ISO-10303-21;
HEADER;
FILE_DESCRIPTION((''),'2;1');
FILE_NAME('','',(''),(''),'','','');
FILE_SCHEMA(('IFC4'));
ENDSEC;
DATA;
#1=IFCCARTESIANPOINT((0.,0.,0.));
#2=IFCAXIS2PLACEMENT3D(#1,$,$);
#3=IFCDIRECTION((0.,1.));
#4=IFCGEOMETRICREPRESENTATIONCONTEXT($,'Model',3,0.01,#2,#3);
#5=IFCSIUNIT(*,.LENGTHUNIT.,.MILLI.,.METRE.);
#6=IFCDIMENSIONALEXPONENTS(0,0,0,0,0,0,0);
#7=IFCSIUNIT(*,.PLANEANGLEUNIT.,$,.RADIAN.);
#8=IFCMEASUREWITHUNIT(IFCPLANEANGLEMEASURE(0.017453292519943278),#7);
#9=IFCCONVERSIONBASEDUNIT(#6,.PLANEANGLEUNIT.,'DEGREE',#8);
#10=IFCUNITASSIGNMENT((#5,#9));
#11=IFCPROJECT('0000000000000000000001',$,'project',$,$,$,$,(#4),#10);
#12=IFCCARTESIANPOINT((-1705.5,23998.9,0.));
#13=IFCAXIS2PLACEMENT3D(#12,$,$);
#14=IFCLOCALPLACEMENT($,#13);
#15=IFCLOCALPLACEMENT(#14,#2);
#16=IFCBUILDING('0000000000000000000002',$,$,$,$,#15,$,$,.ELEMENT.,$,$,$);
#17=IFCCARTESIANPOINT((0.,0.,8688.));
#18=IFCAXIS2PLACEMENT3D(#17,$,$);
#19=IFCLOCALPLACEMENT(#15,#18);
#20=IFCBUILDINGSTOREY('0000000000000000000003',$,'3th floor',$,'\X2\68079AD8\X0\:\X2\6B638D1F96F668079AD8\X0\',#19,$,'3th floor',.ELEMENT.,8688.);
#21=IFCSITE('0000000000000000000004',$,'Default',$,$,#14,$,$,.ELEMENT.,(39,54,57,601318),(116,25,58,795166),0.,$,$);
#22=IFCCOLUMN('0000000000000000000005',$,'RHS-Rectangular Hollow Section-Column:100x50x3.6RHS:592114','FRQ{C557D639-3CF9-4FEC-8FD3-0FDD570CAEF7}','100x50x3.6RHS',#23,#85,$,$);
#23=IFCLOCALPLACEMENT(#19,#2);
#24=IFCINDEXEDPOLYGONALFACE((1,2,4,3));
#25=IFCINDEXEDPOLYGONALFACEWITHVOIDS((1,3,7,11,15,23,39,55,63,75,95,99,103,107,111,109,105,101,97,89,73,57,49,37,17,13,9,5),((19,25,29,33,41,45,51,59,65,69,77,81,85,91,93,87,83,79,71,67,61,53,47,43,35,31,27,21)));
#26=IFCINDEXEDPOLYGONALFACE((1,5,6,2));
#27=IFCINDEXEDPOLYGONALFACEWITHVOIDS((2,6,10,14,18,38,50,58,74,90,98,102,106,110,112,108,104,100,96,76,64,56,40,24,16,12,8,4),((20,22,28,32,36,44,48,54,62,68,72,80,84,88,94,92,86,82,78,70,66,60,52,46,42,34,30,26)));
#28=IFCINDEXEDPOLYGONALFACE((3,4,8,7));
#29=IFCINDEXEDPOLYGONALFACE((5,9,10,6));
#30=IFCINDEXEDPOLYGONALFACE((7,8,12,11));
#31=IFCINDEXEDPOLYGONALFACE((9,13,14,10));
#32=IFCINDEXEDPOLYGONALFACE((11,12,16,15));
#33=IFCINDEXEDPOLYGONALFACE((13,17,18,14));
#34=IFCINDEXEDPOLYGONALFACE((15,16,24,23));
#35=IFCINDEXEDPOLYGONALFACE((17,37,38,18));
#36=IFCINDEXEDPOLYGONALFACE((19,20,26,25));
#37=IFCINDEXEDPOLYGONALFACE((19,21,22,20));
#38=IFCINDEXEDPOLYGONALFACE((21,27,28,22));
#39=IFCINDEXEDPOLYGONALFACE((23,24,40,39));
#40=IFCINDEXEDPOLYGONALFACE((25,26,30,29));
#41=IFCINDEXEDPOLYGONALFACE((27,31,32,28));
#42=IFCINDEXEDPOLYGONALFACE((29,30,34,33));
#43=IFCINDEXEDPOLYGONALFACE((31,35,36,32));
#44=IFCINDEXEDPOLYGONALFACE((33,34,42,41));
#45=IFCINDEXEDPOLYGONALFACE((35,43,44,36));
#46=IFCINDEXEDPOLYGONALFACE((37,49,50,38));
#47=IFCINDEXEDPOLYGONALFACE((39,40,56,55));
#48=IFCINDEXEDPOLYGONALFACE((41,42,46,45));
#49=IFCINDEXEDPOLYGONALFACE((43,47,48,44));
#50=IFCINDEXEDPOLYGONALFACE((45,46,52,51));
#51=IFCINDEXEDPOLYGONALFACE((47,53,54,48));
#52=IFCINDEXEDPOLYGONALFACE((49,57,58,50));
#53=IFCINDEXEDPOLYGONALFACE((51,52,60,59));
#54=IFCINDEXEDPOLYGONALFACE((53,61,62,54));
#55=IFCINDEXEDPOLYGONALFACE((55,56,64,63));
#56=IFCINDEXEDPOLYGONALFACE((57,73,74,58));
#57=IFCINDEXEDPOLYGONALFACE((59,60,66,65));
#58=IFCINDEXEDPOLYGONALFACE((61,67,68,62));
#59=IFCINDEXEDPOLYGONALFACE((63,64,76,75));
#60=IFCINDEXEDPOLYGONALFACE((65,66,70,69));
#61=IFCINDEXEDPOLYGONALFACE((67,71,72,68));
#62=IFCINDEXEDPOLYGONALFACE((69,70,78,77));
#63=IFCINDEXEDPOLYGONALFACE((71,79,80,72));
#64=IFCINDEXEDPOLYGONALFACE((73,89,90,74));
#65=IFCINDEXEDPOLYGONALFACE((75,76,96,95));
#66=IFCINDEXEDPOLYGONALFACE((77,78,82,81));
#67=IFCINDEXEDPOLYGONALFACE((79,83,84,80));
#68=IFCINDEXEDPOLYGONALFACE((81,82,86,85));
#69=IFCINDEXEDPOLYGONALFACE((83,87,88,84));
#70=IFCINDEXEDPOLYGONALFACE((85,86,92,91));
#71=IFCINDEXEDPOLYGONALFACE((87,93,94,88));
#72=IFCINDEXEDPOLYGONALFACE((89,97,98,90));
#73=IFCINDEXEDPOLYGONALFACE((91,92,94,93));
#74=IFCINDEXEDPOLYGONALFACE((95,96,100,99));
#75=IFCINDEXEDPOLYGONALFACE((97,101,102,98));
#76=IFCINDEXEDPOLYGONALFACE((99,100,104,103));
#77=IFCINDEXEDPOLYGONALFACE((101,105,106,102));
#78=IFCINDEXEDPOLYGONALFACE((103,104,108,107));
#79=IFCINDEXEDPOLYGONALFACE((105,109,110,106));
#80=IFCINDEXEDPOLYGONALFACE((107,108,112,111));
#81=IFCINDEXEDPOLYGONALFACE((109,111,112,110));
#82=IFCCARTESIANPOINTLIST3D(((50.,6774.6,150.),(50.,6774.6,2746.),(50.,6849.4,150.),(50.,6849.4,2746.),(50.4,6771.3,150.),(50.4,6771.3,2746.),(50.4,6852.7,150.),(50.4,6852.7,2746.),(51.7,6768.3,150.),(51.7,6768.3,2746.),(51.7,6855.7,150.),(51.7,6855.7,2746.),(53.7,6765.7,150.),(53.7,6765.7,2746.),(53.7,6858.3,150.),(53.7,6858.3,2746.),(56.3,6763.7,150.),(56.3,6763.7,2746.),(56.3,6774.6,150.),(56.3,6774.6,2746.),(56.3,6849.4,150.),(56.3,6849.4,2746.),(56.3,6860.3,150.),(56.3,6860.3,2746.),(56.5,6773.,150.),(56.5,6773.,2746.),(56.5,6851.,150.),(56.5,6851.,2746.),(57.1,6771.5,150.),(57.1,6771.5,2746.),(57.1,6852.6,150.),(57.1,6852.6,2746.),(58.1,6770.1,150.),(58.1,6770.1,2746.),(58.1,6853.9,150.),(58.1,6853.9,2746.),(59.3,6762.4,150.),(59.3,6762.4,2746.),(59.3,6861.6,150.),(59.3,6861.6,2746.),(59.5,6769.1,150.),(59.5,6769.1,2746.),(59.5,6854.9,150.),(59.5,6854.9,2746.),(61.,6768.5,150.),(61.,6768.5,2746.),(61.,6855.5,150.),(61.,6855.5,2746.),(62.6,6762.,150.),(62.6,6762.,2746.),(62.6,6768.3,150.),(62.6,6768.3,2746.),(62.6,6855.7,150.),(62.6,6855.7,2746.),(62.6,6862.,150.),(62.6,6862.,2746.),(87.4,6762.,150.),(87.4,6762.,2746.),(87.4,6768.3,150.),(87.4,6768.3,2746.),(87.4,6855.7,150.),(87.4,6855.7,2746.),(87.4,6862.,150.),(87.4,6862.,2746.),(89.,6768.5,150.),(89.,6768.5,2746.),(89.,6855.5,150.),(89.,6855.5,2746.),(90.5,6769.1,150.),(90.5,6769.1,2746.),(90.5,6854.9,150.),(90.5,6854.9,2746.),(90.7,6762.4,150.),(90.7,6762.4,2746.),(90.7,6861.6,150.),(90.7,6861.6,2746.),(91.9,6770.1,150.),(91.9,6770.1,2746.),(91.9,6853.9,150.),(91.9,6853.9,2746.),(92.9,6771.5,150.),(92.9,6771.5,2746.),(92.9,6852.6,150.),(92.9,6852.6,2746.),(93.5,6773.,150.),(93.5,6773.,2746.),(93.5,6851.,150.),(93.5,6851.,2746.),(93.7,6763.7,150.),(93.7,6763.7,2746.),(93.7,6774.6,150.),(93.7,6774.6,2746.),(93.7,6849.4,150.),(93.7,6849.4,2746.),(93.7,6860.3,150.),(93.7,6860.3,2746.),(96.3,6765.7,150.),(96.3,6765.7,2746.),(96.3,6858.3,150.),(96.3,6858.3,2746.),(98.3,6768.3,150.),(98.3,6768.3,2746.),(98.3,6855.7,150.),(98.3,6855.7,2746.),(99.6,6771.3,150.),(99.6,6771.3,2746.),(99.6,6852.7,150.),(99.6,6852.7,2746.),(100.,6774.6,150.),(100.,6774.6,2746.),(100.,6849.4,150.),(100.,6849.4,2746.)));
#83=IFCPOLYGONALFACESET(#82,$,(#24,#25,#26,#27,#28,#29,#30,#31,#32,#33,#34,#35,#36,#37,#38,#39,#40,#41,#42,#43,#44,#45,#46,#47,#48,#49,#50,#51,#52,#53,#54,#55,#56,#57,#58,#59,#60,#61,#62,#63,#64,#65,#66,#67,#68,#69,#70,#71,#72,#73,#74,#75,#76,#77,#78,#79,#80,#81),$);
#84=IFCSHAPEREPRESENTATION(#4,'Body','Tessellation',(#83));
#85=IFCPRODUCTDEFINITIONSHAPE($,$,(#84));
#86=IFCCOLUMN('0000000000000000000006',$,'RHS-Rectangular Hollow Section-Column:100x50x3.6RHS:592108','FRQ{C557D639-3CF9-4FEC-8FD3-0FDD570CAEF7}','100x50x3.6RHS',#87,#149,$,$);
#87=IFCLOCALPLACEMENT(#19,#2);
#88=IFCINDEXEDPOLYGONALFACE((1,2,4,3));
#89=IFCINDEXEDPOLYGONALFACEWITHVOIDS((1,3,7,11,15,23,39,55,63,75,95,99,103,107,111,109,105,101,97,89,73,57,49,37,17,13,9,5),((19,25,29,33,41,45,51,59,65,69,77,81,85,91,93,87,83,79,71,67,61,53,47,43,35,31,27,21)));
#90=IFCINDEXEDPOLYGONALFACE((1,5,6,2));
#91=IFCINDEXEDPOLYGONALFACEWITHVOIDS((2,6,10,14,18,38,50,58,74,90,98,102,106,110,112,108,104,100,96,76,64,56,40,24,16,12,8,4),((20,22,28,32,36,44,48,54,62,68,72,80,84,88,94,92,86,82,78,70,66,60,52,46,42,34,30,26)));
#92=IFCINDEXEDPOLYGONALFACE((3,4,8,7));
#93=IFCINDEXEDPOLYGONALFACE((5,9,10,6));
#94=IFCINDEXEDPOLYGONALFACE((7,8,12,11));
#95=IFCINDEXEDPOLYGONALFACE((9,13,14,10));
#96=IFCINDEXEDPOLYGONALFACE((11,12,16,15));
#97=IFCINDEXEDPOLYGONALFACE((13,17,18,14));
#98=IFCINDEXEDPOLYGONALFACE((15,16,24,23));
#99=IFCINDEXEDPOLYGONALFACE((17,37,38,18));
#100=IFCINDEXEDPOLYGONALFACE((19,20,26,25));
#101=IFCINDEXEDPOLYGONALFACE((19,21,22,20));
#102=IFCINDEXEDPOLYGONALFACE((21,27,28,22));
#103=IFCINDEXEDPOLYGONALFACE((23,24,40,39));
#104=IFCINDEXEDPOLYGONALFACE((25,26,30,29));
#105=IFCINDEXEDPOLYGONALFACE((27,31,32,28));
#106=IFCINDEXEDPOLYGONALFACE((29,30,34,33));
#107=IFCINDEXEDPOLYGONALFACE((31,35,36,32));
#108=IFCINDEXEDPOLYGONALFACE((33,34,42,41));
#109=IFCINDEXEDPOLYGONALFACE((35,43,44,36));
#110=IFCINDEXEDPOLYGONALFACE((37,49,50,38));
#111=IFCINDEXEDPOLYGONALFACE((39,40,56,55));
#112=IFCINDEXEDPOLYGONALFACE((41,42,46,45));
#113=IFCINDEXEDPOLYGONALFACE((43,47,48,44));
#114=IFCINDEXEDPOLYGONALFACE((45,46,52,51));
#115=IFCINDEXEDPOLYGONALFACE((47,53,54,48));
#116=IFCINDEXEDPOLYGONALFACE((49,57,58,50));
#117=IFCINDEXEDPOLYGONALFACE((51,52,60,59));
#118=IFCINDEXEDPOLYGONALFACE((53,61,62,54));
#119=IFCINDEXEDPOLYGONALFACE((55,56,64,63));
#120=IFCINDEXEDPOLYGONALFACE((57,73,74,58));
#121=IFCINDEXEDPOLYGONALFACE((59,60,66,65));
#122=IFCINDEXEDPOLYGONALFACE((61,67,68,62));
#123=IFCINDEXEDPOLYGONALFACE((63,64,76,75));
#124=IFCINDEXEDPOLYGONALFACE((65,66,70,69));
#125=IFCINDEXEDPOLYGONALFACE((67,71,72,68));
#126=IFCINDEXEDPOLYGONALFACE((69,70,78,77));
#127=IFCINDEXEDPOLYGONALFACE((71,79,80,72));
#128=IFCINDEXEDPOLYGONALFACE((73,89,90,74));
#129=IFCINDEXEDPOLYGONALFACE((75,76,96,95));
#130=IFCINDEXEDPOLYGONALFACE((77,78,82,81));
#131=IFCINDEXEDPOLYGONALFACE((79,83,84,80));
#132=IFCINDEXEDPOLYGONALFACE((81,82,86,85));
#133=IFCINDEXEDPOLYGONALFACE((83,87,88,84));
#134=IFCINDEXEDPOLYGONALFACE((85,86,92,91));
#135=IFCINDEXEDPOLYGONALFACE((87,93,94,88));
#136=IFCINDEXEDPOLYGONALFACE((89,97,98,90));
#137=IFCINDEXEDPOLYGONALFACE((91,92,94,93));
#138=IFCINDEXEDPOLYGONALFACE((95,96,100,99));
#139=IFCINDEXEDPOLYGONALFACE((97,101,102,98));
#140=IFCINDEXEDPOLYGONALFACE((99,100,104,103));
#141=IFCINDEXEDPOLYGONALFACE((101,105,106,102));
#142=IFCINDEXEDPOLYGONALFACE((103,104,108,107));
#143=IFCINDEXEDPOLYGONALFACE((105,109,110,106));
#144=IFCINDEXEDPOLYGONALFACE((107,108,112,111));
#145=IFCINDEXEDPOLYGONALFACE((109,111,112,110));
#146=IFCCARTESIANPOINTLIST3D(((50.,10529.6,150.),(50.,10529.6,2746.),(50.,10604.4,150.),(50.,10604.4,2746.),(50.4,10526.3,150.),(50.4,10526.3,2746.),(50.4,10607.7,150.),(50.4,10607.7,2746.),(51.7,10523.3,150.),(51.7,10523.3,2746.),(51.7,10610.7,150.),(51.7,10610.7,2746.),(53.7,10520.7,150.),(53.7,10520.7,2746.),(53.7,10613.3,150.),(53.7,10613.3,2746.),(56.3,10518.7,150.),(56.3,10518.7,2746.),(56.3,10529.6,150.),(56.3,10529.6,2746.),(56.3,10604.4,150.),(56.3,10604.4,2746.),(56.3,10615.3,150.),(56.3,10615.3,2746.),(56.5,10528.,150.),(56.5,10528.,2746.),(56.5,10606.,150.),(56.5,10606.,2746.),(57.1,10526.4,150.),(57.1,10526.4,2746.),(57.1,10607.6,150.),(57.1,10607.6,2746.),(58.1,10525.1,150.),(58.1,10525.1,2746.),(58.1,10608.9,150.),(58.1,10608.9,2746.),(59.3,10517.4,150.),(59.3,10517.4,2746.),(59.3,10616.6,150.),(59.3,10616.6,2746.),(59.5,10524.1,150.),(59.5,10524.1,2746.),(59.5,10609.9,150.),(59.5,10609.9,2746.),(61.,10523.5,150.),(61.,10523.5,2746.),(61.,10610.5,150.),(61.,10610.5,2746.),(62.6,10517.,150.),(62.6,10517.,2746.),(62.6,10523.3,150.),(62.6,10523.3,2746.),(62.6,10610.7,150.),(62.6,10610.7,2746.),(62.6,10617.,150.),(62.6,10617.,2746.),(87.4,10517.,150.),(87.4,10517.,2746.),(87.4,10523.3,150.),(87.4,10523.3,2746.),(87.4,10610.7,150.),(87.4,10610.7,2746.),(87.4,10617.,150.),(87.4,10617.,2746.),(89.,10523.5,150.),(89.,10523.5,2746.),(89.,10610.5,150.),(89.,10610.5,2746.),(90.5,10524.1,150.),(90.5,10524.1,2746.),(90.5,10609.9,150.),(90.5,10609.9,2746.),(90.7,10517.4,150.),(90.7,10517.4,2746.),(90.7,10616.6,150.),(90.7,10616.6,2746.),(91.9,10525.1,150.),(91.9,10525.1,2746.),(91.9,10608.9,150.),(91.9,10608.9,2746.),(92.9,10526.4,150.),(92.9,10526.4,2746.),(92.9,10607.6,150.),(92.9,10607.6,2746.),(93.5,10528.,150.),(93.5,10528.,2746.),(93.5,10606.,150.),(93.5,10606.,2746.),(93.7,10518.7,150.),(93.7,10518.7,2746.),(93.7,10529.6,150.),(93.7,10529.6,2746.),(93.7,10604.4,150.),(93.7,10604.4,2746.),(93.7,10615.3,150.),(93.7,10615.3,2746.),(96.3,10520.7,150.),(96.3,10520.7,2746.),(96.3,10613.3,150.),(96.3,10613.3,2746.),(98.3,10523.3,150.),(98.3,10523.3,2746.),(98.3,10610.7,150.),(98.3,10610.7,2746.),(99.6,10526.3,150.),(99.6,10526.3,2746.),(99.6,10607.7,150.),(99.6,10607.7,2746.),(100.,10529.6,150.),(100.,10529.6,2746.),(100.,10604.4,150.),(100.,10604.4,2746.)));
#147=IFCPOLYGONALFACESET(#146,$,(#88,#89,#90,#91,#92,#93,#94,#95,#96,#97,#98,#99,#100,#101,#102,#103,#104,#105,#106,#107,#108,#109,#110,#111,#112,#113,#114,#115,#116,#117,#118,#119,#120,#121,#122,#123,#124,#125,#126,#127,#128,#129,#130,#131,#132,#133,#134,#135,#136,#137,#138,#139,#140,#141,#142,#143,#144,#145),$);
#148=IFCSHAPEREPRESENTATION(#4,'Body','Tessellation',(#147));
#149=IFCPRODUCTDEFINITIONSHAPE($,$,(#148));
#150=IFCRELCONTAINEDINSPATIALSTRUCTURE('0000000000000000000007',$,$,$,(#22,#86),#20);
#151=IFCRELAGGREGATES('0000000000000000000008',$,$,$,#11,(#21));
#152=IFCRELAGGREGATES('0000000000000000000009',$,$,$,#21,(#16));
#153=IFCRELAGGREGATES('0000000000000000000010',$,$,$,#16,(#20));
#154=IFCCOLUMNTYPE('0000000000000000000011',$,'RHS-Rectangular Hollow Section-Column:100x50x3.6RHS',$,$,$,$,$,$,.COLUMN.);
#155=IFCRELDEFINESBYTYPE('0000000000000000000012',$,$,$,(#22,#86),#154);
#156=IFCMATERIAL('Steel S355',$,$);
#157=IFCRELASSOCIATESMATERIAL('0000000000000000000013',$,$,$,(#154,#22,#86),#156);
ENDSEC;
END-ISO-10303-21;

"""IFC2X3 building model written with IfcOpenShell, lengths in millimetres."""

from ifc_helpers import new_model, entity, si_unit, converted_unit, point, direction, frame, frame_2d, origin, origin_2d, place, context, project, spatial, circle_curve, line_curve, trimmed, segment, composite_curve, hollow_rectangle, outline, extrude, clip, halfspace, material, type_object, element, save


model = new_model("IFC2X3")

# Units and contexts
model_context = context("Model", 3, precision=0.01, world=origin(), true_north=direction((0.0, 1.0)))
ifc_project = project(units=[si_unit("LENGTHUNIT", "METRE", prefix="MILLI"), converted_unit("PLANEANGLEUNIT", "DEGREE", entity("IfcPlaneAngleMeasure", 0.017453292519943278), si_unit("PLANEANGLEUNIT", "RADIAN"), dimensions=[0, 0, 0, 0, 0, 0, 0])], contexts=[model_context])

# Site, building, storey
site_placement = place(None, frame((-1705.5, 23998.9, 0.0)))
site = spatial("IfcSite", under=ifc_project, at=site_placement, Name="Default", CompositionType="ELEMENT", RefLatitude=(39, 54, 57, 601318), RefLongitude=(116, 25, 58, 795166), RefElevation=0.0)
building_placement = place(site_placement, origin())
building = spatial("IfcBuilding", under=site, at=building_placement, CompositionType="ELEMENT")
storey_placement = place(building_placement, frame((0.0, 0.0, 8688.0)))
storey = spatial("IfcBuildingStorey", under=building, at=storey_placement, Name="3th floor", ObjectType="标高:正负零标高", LongName="3th floor", CompositionType="ELEMENT", Elevation=8688.0)

# Columns, openings
ifc_material_1 = material(Name="Steel S355")
column_type_1 = type_object("IfcColumnType", Name="RHS-Rectangular Hollow Section-Column:100x50x3.6RHS", PredefinedType="COLUMN", material=ifc_material_1)
column_1_placement = place(storey_placement, frame((75.0, 6812.0, 2876.9)))
column_1 = element("IfcColumn", 1, at=column_1_placement, inside=storey, type_object=column_type_1, material=ifc_material_1, Name="RHS-Rectangular Hollow Section-Column:100x50x3.6RHS:592114", Description="FRQ{C557D639-3CF9-4FEC-8FD3-0FDD570CAEF7}", ObjectType="100x50x3.6RHS", context=model_context, shape_type="Clipping", body=[
    clip(clip(extrude(hollow_rectangle(XDim=50.0, YDim=100.0, WallThickness=6.3, InnerFilletRadius=6.3, OuterFilletRadius=12.6, at=origin_2d()), origin(), (0.0, 0.0, -1.0), 2782.8), halfspace(frame((-75.0, -6812.0, -2726.9), z_axis=(0.0, 0.0, 1.0), x_axis=(1.0, 0.0, 0.0)), True)), halfspace(frame((-75.0, -6812.0, -55.9), z_axis=(0.0, 0.0, -1.0), x_axis=(-1.0, 0.0, 0.0)), True)),
])
opening_1_placement = place(column_1_placement, frame((0.0, -150.1, -130.9), z_axis=(0.0, 1.0, 0.0), x_axis=(-1.0, 0.0, 0.0)))
element("IfcOpeningElement", 2, at=opening_1_placement, cuts=column_1, ObjectType="Opening", context=model_context, shape_type="SweptSolid", body=[
    extrude(outline(composite_curve([segment(trimmed(circle_curve(frame_2d((43.0, 32.0), x_axis=(1.0, 0.0)), 32.0), [point((43.0, 0.0))], [point((75.0, 32.0))], True, "CARTESIAN"), True, "CONTINUOUS"), segment(trimmed(line_curve((75.0, 32.0), (0.0, 1.0), 86.0), [point((75.0, 32.0))], [point((75.0, 118.0))], True, "CARTESIAN"), True, "CONTINUOUS"), segment(trimmed(circle_curve(frame_2d((43.0, 118.0), x_axis=(1.0, 0.0)), 32.0), [point((75.0, 118.0))], [point((43.0, 150.0))], True, "CARTESIAN"), True, "CONTINUOUS"), segment(trimmed(line_curve((43.0, 150.0), (-1.0, 0.0), 86.0), [point((43.0, 150.0))], [point((-43.0, 150.0))], True, "CARTESIAN"), True, "CONTINUOUS"), segment(trimmed(circle_curve(frame_2d((-43.0, 118.0), x_axis=(1.0, 0.0)), 32.0), [point((-43.0, 150.0))], [point((-75.0, 118.0))], True, "CARTESIAN"), True, "CONTINUOUS"), segment(trimmed(line_curve((-75.0, 118.0), (0.0, -1.0), 86.0), [point((-75.0, 118.0))], [point((-75.0, 32.0))], True, "CARTESIAN"), True, "CONTINUOUS"), segment(trimmed(circle_curve(frame_2d((-43.0, 32.0), x_axis=(1.0, 0.0)), 32.0), [point((-75.0, 32.0))], [point((-43.0, 0.0))], True, "CARTESIAN"), True, "CONTINUOUS"), segment(trimmed(line_curve((-43.0, 0.0), (1.0, 0.0), 86.0), [point((-43.0, 0.0))], [point((43.0, 0.0))], True, "CARTESIAN"), True, "CONTINUOUS")], self_intersect="UNKNOWN")), origin(), (0.0, 0.0, 1.0), 300.2),
])
column_2_placement = place(storey_placement, frame((75.0, 10567.0, 2876.9)))
column_2 = element("IfcColumn", 3, at=column_2_placement, inside=storey, type_object=column_type_1, material=ifc_material_1, Name="RHS-Rectangular Hollow Section-Column:100x50x3.6RHS:592108", Description="FRQ{C557D639-3CF9-4FEC-8FD3-0FDD570CAEF7}", ObjectType="100x50x3.6RHS", context=model_context, shape_type="Clipping", body=[
    clip(clip(extrude(hollow_rectangle(XDim=50.0, YDim=100.0, WallThickness=6.3, InnerFilletRadius=6.3, OuterFilletRadius=12.6, at=origin_2d()), origin(), (0.0, 0.0, -1.0), 2782.8), halfspace(frame((-75.0, -10567.0, -55.9), z_axis=(0.0, 0.0, -1.0), x_axis=(-1.0, 0.0, 0.0)), True)), halfspace(frame((-75.0, -10567.0, -2726.9), z_axis=(0.0, 0.0, 1.0), x_axis=(1.0, 0.0, 0.0)), True)),
])
opening_2_placement = place(column_2_placement, frame((0.0, -150.1, -130.9), z_axis=(0.0, 1.0, 0.0), x_axis=(-1.0, 0.0, 0.0)))
element("IfcOpeningElement", 4, at=opening_2_placement, cuts=column_2, ObjectType="Opening", context=model_context, shape_type="SweptSolid", body=[
    extrude(outline(composite_curve([segment(trimmed(circle_curve(frame_2d((43.0, 32.0), x_axis=(1.0, 0.0)), 32.0), [point((43.0, 0.0))], [point((75.0, 32.0))], True, "CARTESIAN"), True, "CONTINUOUS"), segment(trimmed(line_curve((75.0, 32.0), (0.0, 1.0), 86.0), [point((75.0, 32.0))], [point((75.0, 118.0))], True, "CARTESIAN"), True, "CONTINUOUS"), segment(trimmed(circle_curve(frame_2d((43.0, 118.0), x_axis=(1.0, 0.0)), 32.0), [point((75.0, 118.0))], [point((43.0, 150.0))], True, "CARTESIAN"), True, "CONTINUOUS"), segment(trimmed(line_curve((43.0, 150.0), (-1.0, 0.0), 86.0), [point((43.0, 150.0))], [point((-43.0, 150.0))], True, "CARTESIAN"), True, "CONTINUOUS"), segment(trimmed(circle_curve(frame_2d((-43.0, 118.0), x_axis=(1.0, 0.0)), 32.0), [point((-43.0, 150.0))], [point((-75.0, 118.0))], True, "CARTESIAN"), True, "CONTINUOUS"), segment(trimmed(line_curve((-75.0, 118.0), (0.0, -1.0), 86.0), [point((-75.0, 118.0))], [point((-75.0, 32.0))], True, "CARTESIAN"), True, "CONTINUOUS"), segment(trimmed(circle_curve(frame_2d((-43.0, 32.0), x_axis=(1.0, 0.0)), 32.0), [point((-75.0, 32.0))], [point((-43.0, 0.0))], True, "CARTESIAN"), True, "CONTINUOUS"), segment(trimmed(line_curve((-43.0, 0.0), (1.0, 0.0), 86.0), [point((-43.0, 0.0))], [point((43.0, 0.0))], True, "CARTESIAN"), True, "CONTINUOUS")], self_intersect="UNKNOWN")), origin(), (0.0, 0.0, 1.0), 300.2),
])

save(model, "model.ifc")
